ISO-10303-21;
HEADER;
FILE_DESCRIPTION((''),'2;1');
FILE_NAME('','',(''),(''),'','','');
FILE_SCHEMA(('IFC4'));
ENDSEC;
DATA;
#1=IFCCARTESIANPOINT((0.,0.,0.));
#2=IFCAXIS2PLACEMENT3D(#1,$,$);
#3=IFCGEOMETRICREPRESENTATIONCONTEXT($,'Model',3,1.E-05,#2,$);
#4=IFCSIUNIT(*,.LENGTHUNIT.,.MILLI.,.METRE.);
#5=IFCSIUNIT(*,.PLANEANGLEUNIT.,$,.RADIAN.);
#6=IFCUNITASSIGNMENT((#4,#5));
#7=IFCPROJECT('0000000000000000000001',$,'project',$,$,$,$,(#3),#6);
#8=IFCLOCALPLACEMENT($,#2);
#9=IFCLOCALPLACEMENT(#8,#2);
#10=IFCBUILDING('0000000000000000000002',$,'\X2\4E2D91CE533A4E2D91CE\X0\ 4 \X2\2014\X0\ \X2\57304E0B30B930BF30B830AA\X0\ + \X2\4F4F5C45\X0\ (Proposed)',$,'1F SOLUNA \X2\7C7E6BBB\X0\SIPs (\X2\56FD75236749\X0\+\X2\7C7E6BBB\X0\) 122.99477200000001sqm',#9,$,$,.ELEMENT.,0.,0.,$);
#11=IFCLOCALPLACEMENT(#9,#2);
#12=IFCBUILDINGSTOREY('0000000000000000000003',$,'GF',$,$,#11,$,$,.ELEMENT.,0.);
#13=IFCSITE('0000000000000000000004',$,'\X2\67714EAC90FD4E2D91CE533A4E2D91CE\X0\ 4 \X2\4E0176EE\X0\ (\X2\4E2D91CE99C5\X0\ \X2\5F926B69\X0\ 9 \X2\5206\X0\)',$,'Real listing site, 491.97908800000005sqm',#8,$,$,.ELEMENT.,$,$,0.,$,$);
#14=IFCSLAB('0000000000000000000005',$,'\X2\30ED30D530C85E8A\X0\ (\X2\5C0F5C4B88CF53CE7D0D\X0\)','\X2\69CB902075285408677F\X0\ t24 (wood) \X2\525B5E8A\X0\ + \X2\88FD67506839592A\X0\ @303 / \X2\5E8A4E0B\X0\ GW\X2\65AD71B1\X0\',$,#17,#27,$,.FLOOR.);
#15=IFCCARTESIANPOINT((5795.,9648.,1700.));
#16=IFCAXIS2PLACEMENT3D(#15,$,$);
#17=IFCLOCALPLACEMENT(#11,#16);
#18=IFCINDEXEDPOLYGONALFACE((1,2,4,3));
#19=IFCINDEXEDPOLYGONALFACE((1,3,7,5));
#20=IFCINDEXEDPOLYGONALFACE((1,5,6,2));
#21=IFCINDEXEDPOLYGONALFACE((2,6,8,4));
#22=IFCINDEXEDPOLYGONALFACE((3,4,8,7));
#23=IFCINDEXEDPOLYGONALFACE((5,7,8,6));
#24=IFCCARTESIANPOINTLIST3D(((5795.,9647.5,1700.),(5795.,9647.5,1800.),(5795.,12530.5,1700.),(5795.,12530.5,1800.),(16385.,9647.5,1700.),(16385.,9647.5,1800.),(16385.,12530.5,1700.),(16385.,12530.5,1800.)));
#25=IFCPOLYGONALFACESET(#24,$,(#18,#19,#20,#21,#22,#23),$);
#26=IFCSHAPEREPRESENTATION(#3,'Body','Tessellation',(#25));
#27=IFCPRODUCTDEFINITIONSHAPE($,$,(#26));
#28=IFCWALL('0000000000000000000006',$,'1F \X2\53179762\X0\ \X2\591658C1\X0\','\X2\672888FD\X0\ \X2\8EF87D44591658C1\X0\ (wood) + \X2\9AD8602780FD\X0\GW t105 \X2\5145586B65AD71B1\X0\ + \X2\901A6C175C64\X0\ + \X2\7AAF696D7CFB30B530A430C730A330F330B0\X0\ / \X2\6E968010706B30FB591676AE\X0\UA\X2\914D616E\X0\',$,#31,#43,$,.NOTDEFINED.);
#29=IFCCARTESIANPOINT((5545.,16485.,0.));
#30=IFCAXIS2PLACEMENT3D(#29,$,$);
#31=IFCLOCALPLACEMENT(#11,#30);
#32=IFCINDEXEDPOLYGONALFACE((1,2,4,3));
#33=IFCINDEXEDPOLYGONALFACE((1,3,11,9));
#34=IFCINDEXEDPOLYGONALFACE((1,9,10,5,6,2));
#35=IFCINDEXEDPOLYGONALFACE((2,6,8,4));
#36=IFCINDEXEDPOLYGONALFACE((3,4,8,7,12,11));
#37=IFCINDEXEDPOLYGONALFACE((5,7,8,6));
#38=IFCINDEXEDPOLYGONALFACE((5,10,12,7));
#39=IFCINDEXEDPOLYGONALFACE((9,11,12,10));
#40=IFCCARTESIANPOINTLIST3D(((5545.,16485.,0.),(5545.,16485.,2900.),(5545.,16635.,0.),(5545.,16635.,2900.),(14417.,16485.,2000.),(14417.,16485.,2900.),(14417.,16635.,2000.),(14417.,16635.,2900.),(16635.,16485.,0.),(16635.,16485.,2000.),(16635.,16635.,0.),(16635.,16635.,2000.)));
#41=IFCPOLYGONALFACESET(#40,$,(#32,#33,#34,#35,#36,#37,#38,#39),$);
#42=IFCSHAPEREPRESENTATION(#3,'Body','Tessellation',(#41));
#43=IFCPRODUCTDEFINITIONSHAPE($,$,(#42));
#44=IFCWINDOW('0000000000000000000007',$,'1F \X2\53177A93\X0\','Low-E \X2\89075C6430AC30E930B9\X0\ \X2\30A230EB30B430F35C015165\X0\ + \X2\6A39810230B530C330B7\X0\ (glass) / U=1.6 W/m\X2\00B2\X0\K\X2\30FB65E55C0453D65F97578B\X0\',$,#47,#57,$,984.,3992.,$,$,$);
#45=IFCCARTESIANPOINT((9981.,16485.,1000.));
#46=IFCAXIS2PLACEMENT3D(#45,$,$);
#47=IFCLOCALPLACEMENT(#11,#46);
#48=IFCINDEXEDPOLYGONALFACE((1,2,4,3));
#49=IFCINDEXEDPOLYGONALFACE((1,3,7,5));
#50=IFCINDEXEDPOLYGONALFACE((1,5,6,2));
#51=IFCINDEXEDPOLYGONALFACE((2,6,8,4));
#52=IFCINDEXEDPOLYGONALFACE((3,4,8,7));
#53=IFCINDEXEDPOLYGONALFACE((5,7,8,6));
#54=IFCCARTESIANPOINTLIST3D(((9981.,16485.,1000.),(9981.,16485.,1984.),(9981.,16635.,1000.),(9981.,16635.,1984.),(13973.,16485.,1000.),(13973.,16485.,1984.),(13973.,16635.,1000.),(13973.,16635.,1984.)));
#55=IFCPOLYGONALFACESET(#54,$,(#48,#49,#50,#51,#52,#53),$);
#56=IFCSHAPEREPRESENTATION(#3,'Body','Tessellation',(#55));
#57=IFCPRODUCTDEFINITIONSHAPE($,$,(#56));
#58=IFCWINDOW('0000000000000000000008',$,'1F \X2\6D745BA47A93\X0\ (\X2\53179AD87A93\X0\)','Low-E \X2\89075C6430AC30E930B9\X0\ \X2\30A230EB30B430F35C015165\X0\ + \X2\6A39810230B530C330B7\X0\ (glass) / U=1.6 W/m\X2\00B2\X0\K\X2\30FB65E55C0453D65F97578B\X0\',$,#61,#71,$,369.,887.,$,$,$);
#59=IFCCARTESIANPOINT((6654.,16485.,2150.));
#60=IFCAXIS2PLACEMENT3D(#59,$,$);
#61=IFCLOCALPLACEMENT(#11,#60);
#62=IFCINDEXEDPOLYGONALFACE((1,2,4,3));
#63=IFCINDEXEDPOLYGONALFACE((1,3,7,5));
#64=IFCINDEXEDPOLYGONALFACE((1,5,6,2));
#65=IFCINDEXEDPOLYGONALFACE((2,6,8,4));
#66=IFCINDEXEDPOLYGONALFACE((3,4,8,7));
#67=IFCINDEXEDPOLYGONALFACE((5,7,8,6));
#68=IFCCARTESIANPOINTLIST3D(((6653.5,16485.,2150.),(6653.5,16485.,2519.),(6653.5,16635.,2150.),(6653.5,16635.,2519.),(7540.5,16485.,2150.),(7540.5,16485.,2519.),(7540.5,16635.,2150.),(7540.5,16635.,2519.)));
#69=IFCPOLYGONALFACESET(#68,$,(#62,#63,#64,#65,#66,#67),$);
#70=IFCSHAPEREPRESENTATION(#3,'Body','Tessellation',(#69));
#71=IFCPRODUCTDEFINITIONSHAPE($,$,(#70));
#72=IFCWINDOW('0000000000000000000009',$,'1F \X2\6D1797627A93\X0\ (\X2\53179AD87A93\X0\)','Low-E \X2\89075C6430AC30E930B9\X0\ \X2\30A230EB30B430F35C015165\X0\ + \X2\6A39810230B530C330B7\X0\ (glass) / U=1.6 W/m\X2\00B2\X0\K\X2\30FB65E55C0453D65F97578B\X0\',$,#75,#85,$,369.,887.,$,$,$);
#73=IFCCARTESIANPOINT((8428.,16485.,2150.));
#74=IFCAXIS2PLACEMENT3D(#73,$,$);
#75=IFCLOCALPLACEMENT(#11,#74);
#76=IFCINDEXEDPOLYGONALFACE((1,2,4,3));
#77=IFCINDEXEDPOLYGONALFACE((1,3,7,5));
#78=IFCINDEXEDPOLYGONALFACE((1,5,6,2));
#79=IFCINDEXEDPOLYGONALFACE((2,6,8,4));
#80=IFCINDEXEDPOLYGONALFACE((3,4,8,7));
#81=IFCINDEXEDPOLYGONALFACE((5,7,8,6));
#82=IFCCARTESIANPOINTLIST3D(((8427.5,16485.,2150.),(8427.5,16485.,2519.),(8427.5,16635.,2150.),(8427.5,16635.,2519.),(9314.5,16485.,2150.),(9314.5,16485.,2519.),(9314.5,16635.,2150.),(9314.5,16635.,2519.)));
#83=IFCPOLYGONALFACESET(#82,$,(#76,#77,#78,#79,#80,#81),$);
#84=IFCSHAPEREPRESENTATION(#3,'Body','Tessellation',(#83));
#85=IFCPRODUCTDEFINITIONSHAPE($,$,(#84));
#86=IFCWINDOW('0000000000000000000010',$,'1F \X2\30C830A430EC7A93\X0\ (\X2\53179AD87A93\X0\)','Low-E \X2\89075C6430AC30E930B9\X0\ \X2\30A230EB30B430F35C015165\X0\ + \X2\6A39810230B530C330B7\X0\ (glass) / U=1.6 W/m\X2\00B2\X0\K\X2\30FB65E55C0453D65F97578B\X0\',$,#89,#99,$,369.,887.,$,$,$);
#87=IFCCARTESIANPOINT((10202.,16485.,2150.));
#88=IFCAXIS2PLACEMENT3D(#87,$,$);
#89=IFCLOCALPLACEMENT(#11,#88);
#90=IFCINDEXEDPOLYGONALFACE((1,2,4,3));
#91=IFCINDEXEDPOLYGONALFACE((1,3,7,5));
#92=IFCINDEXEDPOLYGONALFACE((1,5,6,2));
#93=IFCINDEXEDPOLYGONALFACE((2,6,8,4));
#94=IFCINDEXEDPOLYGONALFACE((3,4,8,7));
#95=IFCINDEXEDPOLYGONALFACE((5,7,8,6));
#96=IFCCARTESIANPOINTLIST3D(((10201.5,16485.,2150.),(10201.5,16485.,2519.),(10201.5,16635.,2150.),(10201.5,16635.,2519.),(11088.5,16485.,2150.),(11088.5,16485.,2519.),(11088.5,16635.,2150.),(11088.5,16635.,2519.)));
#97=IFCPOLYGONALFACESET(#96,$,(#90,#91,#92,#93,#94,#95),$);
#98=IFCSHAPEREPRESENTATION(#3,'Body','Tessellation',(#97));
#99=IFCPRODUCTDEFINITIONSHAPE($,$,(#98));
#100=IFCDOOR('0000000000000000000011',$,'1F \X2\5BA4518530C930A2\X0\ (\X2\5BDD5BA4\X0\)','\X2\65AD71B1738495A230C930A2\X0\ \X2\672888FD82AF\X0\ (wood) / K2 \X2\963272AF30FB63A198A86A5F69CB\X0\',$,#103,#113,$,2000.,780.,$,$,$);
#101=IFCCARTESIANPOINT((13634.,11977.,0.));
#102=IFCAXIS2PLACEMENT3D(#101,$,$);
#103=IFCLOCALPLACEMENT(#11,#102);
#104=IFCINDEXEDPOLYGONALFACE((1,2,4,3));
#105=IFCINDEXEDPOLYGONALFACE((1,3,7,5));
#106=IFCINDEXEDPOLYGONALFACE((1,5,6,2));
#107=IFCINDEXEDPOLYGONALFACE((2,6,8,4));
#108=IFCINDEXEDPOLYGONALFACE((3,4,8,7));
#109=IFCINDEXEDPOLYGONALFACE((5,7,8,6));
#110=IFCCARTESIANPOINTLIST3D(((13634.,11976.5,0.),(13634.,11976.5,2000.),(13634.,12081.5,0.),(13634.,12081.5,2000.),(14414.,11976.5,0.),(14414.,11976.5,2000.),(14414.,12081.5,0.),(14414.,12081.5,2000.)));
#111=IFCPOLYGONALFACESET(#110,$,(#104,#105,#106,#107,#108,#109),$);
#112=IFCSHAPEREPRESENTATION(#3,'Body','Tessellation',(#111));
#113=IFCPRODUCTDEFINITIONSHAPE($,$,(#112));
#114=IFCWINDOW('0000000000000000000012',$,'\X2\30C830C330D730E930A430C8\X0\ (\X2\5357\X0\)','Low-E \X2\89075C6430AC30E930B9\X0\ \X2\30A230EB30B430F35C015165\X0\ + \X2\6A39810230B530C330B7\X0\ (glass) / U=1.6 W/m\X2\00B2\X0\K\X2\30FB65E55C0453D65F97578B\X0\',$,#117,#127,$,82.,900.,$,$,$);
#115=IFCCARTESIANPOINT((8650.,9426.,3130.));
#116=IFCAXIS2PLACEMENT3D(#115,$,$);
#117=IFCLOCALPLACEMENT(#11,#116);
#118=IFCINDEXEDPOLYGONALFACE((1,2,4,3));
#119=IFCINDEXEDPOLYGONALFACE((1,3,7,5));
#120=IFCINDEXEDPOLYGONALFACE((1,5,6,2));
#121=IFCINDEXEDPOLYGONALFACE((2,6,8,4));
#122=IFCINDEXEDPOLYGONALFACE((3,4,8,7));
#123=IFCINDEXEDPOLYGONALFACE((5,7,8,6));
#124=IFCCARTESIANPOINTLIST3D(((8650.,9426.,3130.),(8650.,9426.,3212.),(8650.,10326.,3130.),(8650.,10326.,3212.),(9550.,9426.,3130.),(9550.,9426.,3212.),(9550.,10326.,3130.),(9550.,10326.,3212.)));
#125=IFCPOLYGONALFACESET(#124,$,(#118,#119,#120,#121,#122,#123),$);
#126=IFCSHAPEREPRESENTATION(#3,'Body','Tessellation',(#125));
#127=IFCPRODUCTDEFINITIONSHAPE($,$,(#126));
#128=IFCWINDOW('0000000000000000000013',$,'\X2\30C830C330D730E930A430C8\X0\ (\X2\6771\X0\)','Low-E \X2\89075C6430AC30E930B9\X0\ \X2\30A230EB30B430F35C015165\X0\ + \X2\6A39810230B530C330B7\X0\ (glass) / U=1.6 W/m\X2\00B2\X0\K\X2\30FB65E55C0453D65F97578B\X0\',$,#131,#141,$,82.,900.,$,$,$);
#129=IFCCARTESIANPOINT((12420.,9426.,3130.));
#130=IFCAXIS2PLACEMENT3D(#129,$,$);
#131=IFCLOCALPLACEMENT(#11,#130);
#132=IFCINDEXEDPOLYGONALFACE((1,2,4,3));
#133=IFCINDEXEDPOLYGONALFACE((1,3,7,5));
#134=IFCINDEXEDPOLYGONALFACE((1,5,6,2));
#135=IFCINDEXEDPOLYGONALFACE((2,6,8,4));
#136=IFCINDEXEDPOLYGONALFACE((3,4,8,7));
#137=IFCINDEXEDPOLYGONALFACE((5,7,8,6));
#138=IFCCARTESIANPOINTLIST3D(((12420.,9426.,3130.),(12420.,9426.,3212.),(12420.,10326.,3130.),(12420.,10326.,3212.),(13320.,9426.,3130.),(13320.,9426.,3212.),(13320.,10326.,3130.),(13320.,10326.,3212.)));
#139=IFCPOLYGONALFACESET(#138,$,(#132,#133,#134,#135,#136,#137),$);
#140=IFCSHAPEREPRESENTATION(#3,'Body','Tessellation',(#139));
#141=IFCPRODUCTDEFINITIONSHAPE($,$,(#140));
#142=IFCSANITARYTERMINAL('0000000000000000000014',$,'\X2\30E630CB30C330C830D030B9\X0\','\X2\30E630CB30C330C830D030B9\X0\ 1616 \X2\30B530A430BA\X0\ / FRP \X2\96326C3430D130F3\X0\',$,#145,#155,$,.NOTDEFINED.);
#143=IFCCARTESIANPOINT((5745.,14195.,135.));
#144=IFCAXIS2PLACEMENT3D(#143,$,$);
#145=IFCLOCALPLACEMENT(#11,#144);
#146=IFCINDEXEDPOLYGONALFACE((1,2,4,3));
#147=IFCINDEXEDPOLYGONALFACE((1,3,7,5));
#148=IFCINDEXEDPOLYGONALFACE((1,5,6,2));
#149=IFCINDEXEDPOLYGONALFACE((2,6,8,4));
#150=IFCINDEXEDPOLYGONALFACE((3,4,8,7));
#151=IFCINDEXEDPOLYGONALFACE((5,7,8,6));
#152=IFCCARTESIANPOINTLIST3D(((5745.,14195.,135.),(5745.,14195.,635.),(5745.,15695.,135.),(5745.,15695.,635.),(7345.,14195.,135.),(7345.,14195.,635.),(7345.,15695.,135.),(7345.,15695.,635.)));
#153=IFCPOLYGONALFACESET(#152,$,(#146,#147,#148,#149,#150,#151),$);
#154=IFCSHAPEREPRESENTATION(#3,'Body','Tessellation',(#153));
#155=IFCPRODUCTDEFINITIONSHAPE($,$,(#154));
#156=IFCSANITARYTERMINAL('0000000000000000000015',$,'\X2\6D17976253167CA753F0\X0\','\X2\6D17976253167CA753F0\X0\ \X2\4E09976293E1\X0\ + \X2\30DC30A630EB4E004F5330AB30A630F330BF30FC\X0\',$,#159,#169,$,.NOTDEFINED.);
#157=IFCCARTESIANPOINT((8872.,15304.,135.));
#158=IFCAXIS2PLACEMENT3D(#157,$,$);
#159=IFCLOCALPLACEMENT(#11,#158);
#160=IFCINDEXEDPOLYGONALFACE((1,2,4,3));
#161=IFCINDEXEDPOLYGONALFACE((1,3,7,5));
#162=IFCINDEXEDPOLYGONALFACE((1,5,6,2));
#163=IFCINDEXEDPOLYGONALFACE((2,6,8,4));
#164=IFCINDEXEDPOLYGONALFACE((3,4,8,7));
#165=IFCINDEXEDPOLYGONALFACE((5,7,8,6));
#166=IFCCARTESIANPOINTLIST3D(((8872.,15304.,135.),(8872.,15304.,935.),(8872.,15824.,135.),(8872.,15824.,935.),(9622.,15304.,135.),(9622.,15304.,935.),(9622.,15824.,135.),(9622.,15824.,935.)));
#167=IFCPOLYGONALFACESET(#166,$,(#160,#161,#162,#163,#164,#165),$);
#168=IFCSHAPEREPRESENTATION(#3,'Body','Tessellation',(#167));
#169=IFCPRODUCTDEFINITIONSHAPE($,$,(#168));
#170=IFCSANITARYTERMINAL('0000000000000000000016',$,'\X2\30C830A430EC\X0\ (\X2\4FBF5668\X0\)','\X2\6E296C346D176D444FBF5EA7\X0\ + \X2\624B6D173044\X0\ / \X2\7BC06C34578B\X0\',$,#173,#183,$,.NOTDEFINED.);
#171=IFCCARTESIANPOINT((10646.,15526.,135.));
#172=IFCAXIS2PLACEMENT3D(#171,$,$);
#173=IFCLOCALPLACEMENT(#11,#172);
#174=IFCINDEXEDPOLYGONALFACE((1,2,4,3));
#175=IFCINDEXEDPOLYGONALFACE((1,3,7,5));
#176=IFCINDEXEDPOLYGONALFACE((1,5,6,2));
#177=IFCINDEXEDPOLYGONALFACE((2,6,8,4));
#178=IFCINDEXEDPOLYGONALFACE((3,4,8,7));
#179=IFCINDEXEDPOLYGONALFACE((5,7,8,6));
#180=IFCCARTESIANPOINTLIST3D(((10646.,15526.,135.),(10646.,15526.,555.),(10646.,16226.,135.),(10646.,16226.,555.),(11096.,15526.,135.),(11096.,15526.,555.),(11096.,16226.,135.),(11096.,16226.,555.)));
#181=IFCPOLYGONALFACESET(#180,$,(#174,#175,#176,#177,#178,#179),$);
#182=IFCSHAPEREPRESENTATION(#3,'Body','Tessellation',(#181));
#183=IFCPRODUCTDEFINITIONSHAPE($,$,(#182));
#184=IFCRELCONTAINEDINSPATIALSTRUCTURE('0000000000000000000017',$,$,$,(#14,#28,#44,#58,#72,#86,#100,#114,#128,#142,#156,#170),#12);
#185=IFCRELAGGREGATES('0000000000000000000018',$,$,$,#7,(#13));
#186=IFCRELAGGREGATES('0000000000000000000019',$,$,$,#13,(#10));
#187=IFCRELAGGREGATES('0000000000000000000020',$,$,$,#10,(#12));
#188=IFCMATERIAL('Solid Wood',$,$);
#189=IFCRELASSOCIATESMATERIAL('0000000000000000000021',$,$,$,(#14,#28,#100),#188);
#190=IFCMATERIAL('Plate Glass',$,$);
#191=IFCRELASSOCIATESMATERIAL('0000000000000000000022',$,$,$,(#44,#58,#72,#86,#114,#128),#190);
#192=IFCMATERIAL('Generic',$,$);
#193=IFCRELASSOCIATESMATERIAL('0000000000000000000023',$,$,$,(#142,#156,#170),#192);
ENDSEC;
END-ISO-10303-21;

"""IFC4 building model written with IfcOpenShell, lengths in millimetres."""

from ifc_helpers import new_model, si_unit, frame, frame_2d, origin, place, context, project, spatial, rectangle, extrude, material, element, fill, save


model = new_model("IFC4")

# Units and contexts
model_context = context("Model", 3, precision=1e-05, world=origin())
ifc_project = project(units=[si_unit("LENGTHUNIT", "METRE", prefix="MILLI"), si_unit("PLANEANGLEUNIT", "RADIAN")], contexts=[model_context])

# Site, building, storey
site_placement = place(None, origin())
site = spatial("IfcSite", under=ifc_project, at=site_placement, Name="東京都中野区中野 4 丁目 (中野駅 徒歩 9 分)", ObjectType="Real listing site, 491.97908800000005sqm", CompositionType="ELEMENT", RefElevation=0.0)
building_placement = place(site_placement, origin())
building = spatial("IfcBuilding", under=site, at=building_placement, Name="中野区中野 4 — 地下スタジオ + 住居 (Proposed)", ObjectType="1F SOLUNA 籾殻SIPs (国産杉+籾殻) 122.99477200000001sqm", CompositionType="ELEMENT", ElevationOfRefHeight=0.0, ElevationOfTerrain=0.0)
storey_placement = place(building_placement, origin())
storey = spatial("IfcBuildingStorey", under=building, at=storey_placement, Name="GF", CompositionType="ELEMENT", Elevation=0.0)

# Slab
ifc_material_1 = material(Name="Solid Wood")
slab_placement = place(storey_placement, frame((5795.0, 9648.0, 1700.0)))
element("IfcSlab", 1, at=slab_placement, inside=storey, material=ifc_material_1, Name="ロフト床 (小屋裏収納)", Description="構造用合板 t24 (wood) 剛床 + 製材根太 @303 / 床下 GW断熱", PredefinedType="FLOOR", context=model_context, shape_type="SweptSolid", body=[
    extrude(rectangle(XDim=10590.0, YDim=2883.0, at=frame_2d((5295.0, 1441.0))), frame((5795.0, 9648.0, 1700.0)), (0.0, 0.0, 1.0), 100.0),
])

# Wall, openings, windows
wall_1_placement = place(storey_placement, frame((5545.0, 16485.0, 0.0)))
wall_1 = element("IfcWall", 2, at=wall_1_placement, inside=storey, material=ifc_material_1, Name="1F 北面 外壁", Description="木製 軸組外壁 (wood) + 高性能GW t105 充填断熱 + 通気層 + 窯業系サイディング / 準耐火・外皮UA配慮", PredefinedType="NOTDEFINED", context=model_context, shape_type="SweptSolid", body=[
    extrude(rectangle(XDim=11090.0, YDim=150.0, at=frame_2d((5545.0, 75.0))), frame((5545.0, 16485.0, 0.0)), (0.0, 0.0, 1.0), 2900.0),
])
opening_1_placement = place(storey_placement, frame((9981.0, 16485.0, 1000.0)))
opening_1 = element("IfcOpeningElement", 3, at=opening_1_placement, cuts=wall_1, PredefinedType="NOTDEFINED", context=model_context, shape_type="SweptSolid", body=[
    extrude(rectangle(XDim=3992.0, YDim=150.0, at=frame_2d((1996.0, 75.0))), frame((9981.0, 16485.0, 1000.0)), (0.0, 0.0, 1.0), 984.0),
])
opening_2_placement = place(storey_placement, frame((6654.0, 16485.0, 2150.0)))
opening_2 = element("IfcOpeningElement", 4, at=opening_2_placement, cuts=wall_1, PredefinedType="NOTDEFINED", context=model_context, shape_type="SweptSolid", body=[
    extrude(rectangle(XDim=887.0, YDim=150.0, at=frame_2d((443.0, 75.0))), frame((6654.0, 16485.0, 2150.0)), (0.0, 0.0, 1.0), 369.0),
])
opening_3_placement = place(storey_placement, frame((8428.0, 16485.0, 2150.0)))
opening_3 = element("IfcOpeningElement", 5, at=opening_3_placement, cuts=wall_1, PredefinedType="NOTDEFINED", context=model_context, shape_type="SweptSolid", body=[
    extrude(rectangle(XDim=887.0, YDim=150.0, at=frame_2d((443.0, 75.0))), frame((8428.0, 16485.0, 2150.0)), (0.0, 0.0, 1.0), 369.0),
])
opening_4_placement = place(storey_placement, frame((10202.0, 16485.0, 2150.0)))
opening_4 = element("IfcOpeningElement", 6, at=opening_4_placement, cuts=wall_1, PredefinedType="NOTDEFINED", context=model_context, shape_type="SweptSolid", body=[
    extrude(rectangle(XDim=887.0, YDim=150.0, at=frame_2d((443.0, 75.0))), frame((10202.0, 16485.0, 2150.0)), (0.0, 0.0, 1.0), 369.0),
])
ifc_material_2 = material(Name="Plate Glass")
window_1_placement = place(storey_placement, frame((9981.0, 16485.0, 1000.0)))
window_1 = element("IfcWindow", 7, at=window_1_placement, inside=storey, material=ifc_material_2, Name="1F 北窓", Description="Low-E 複層ガラス アルゴン封入 + 樹脂サッシ (glass) / U=1.6 W/m²K・日射取得型", OverallHeight=984.0, OverallWidth=3992.0, context=model_context, shape_type="SweptSolid", body=[
    extrude(rectangle(XDim=3992.0, YDim=150.0, at=frame_2d((1996.0, 75.0))), frame((9981.0, 16485.0, 1000.0)), (0.0, 0.0, 1.0), 984.0),
])
fill(opening_1, window_1)
window_2_placement = place(storey_placement, frame((6654.0, 16485.0, 2150.0)))
window_2 = element("IfcWindow", 8, at=window_2_placement, inside=storey, material=ifc_material_2, Name="1F 浴室窓 (北高窓)", Description="Low-E 複層ガラス アルゴン封入 + 樹脂サッシ (glass) / U=1.6 W/m²K・日射取得型", OverallHeight=369.0, OverallWidth=887.0, context=model_context, shape_type="SweptSolid", body=[
    extrude(rectangle(XDim=887.0, YDim=150.0, at=frame_2d((443.0, 75.0))), frame((6654.0, 16485.0, 2150.0)), (0.0, 0.0, 1.0), 369.0),
])
fill(opening_2, window_2)
window_3_placement = place(storey_placement, frame((8428.0, 16485.0, 2150.0)))
window_3 = element("IfcWindow", 9, at=window_3_placement, inside=storey, material=ifc_material_2, Name="1F 洗面窓 (北高窓)", Description="Low-E 複層ガラス アルゴン封入 + 樹脂サッシ (glass) / U=1.6 W/m²K・日射取得型", OverallHeight=369.0, OverallWidth=887.0, context=model_context, shape_type="SweptSolid", body=[
    extrude(rectangle(XDim=887.0, YDim=150.0, at=frame_2d((443.0, 75.0))), frame((8428.0, 16485.0, 2150.0)), (0.0, 0.0, 1.0), 369.0),
])
fill(opening_3, window_3)
window_4_placement = place(storey_placement, frame((10202.0, 16485.0, 2150.0)))
window_4 = element("IfcWindow", 10, at=window_4_placement, inside=storey, material=ifc_material_2, Name="1F トイレ窓 (北高窓)", Description="Low-E 複層ガラス アルゴン封入 + 樹脂サッシ (glass) / U=1.6 W/m²K・日射取得型", OverallHeight=369.0, OverallWidth=887.0, context=model_context, shape_type="SweptSolid", body=[
    extrude(rectangle(XDim=887.0, YDim=150.0, at=frame_2d((443.0, 75.0))), frame((10202.0, 16485.0, 2150.0)), (0.0, 0.0, 1.0), 369.0),
])
fill(opening_4, window_4)

# Door
door_1_placement = place(storey_placement, frame((13634.0, 11977.0, 0.0)))
element("IfcDoor", 11, at=door_1_placement, inside=storey, material=ifc_material_1, Name="1F 室内ドア (寝室)", Description="断熱玄関ドア 木製芯 (wood) / K2 防犯・採風機構", OverallHeight=2000.0, OverallWidth=780.0, context=model_context, shape_type="SweptSolid", body=[
    extrude(rectangle(XDim=780.0, YDim=105.0, at=frame_2d((390.0, 52.0))), frame((13634.0, 11977.0, 0.0)), (0.0, 0.0, 1.0), 2000.0),
])

# Windows
window_5_placement = place(storey_placement, frame((8650.0, 9426.0, 3130.0)))
element("IfcWindow", 12, at=window_5_placement, inside=storey, material=ifc_material_2, Name="トップライト (南)", Description="Low-E 複層ガラス アルゴン封入 + 樹脂サッシ (glass) / U=1.6 W/m²K・日射取得型", OverallHeight=82.0, OverallWidth=900.0, context=model_context, shape_type="SweptSolid", body=[
    extrude(rectangle(XDim=900.0, YDim=900.0, at=frame_2d((450.0, 450.0))), frame((8650.0, 9426.0, 3130.0)), (0.0, 0.0, 1.0), 82.0),
])
window_6_placement = place(storey_placement, frame((12420.0, 9426.0, 3130.0)))
element("IfcWindow", 13, at=window_6_placement, inside=storey, material=ifc_material_2, Name="トップライト (東)", Description="Low-E 複層ガラス アルゴン封入 + 樹脂サッシ (glass) / U=1.6 W/m²K・日射取得型", OverallHeight=82.0, OverallWidth=900.0, context=model_context, shape_type="SweptSolid", body=[
    extrude(rectangle(XDim=900.0, YDim=900.0, at=frame_2d((450.0, 450.0))), frame((12420.0, 9426.0, 3130.0)), (0.0, 0.0, 1.0), 82.0),
])

# Sanitary terminals
ifc_material_3 = material(Name="Generic")
sanitary_terminal_1_placement = place(storey_placement, frame((5745.0, 14195.0, 135.0)))
element("IfcSanitaryTerminal", 14, at=sanitary_terminal_1_placement, inside=storey, material=ifc_material_3, Name="ユニットバス", Description="ユニットバス 1616 サイズ / FRP 防水パン", PredefinedType="NOTDEFINED", context=model_context, shape_type="SweptSolid", body=[
    extrude(rectangle(XDim=1600.0, YDim=1500.0, at=frame_2d((800.0, 750.0))), frame((5745.0, 14195.0, 135.0)), (0.0, 0.0, 1.0), 500.0),
])
sanitary_terminal_2_placement = place(storey_placement, frame((8872.0, 15304.0, 135.0)))
element("IfcSanitaryTerminal", 15, at=sanitary_terminal_2_placement, inside=storey, material=ifc_material_3, Name="洗面化粧台", Description="洗面化粧台 三面鏡 + ボウル一体カウンター", PredefinedType="NOTDEFINED", context=model_context, shape_type="SweptSolid", body=[
    extrude(rectangle(XDim=750.0, YDim=520.0, at=frame_2d((375.0, 260.0))), frame((8872.0, 15304.0, 135.0)), (0.0, 0.0, 1.0), 800.0),
])
sanitary_terminal_3_placement = place(storey_placement, frame((10646.0, 15526.0, 135.0)))
element("IfcSanitaryTerminal", 16, at=sanitary_terminal_3_placement, inside=storey, material=ifc_material_3, Name="トイレ (便器)", Description="温水洗浄便座 + 手洗い / 節水型", PredefinedType="NOTDEFINED", context=model_context, shape_type="SweptSolid", body=[
    extrude(rectangle(XDim=450.0, YDim=700.0, at=frame_2d((225.0, 350.0))), frame((10646.0, 15526.0, 135.0)), (0.0, 0.0, 1.0), 420.0),
])

save(model, "model.ifc")
